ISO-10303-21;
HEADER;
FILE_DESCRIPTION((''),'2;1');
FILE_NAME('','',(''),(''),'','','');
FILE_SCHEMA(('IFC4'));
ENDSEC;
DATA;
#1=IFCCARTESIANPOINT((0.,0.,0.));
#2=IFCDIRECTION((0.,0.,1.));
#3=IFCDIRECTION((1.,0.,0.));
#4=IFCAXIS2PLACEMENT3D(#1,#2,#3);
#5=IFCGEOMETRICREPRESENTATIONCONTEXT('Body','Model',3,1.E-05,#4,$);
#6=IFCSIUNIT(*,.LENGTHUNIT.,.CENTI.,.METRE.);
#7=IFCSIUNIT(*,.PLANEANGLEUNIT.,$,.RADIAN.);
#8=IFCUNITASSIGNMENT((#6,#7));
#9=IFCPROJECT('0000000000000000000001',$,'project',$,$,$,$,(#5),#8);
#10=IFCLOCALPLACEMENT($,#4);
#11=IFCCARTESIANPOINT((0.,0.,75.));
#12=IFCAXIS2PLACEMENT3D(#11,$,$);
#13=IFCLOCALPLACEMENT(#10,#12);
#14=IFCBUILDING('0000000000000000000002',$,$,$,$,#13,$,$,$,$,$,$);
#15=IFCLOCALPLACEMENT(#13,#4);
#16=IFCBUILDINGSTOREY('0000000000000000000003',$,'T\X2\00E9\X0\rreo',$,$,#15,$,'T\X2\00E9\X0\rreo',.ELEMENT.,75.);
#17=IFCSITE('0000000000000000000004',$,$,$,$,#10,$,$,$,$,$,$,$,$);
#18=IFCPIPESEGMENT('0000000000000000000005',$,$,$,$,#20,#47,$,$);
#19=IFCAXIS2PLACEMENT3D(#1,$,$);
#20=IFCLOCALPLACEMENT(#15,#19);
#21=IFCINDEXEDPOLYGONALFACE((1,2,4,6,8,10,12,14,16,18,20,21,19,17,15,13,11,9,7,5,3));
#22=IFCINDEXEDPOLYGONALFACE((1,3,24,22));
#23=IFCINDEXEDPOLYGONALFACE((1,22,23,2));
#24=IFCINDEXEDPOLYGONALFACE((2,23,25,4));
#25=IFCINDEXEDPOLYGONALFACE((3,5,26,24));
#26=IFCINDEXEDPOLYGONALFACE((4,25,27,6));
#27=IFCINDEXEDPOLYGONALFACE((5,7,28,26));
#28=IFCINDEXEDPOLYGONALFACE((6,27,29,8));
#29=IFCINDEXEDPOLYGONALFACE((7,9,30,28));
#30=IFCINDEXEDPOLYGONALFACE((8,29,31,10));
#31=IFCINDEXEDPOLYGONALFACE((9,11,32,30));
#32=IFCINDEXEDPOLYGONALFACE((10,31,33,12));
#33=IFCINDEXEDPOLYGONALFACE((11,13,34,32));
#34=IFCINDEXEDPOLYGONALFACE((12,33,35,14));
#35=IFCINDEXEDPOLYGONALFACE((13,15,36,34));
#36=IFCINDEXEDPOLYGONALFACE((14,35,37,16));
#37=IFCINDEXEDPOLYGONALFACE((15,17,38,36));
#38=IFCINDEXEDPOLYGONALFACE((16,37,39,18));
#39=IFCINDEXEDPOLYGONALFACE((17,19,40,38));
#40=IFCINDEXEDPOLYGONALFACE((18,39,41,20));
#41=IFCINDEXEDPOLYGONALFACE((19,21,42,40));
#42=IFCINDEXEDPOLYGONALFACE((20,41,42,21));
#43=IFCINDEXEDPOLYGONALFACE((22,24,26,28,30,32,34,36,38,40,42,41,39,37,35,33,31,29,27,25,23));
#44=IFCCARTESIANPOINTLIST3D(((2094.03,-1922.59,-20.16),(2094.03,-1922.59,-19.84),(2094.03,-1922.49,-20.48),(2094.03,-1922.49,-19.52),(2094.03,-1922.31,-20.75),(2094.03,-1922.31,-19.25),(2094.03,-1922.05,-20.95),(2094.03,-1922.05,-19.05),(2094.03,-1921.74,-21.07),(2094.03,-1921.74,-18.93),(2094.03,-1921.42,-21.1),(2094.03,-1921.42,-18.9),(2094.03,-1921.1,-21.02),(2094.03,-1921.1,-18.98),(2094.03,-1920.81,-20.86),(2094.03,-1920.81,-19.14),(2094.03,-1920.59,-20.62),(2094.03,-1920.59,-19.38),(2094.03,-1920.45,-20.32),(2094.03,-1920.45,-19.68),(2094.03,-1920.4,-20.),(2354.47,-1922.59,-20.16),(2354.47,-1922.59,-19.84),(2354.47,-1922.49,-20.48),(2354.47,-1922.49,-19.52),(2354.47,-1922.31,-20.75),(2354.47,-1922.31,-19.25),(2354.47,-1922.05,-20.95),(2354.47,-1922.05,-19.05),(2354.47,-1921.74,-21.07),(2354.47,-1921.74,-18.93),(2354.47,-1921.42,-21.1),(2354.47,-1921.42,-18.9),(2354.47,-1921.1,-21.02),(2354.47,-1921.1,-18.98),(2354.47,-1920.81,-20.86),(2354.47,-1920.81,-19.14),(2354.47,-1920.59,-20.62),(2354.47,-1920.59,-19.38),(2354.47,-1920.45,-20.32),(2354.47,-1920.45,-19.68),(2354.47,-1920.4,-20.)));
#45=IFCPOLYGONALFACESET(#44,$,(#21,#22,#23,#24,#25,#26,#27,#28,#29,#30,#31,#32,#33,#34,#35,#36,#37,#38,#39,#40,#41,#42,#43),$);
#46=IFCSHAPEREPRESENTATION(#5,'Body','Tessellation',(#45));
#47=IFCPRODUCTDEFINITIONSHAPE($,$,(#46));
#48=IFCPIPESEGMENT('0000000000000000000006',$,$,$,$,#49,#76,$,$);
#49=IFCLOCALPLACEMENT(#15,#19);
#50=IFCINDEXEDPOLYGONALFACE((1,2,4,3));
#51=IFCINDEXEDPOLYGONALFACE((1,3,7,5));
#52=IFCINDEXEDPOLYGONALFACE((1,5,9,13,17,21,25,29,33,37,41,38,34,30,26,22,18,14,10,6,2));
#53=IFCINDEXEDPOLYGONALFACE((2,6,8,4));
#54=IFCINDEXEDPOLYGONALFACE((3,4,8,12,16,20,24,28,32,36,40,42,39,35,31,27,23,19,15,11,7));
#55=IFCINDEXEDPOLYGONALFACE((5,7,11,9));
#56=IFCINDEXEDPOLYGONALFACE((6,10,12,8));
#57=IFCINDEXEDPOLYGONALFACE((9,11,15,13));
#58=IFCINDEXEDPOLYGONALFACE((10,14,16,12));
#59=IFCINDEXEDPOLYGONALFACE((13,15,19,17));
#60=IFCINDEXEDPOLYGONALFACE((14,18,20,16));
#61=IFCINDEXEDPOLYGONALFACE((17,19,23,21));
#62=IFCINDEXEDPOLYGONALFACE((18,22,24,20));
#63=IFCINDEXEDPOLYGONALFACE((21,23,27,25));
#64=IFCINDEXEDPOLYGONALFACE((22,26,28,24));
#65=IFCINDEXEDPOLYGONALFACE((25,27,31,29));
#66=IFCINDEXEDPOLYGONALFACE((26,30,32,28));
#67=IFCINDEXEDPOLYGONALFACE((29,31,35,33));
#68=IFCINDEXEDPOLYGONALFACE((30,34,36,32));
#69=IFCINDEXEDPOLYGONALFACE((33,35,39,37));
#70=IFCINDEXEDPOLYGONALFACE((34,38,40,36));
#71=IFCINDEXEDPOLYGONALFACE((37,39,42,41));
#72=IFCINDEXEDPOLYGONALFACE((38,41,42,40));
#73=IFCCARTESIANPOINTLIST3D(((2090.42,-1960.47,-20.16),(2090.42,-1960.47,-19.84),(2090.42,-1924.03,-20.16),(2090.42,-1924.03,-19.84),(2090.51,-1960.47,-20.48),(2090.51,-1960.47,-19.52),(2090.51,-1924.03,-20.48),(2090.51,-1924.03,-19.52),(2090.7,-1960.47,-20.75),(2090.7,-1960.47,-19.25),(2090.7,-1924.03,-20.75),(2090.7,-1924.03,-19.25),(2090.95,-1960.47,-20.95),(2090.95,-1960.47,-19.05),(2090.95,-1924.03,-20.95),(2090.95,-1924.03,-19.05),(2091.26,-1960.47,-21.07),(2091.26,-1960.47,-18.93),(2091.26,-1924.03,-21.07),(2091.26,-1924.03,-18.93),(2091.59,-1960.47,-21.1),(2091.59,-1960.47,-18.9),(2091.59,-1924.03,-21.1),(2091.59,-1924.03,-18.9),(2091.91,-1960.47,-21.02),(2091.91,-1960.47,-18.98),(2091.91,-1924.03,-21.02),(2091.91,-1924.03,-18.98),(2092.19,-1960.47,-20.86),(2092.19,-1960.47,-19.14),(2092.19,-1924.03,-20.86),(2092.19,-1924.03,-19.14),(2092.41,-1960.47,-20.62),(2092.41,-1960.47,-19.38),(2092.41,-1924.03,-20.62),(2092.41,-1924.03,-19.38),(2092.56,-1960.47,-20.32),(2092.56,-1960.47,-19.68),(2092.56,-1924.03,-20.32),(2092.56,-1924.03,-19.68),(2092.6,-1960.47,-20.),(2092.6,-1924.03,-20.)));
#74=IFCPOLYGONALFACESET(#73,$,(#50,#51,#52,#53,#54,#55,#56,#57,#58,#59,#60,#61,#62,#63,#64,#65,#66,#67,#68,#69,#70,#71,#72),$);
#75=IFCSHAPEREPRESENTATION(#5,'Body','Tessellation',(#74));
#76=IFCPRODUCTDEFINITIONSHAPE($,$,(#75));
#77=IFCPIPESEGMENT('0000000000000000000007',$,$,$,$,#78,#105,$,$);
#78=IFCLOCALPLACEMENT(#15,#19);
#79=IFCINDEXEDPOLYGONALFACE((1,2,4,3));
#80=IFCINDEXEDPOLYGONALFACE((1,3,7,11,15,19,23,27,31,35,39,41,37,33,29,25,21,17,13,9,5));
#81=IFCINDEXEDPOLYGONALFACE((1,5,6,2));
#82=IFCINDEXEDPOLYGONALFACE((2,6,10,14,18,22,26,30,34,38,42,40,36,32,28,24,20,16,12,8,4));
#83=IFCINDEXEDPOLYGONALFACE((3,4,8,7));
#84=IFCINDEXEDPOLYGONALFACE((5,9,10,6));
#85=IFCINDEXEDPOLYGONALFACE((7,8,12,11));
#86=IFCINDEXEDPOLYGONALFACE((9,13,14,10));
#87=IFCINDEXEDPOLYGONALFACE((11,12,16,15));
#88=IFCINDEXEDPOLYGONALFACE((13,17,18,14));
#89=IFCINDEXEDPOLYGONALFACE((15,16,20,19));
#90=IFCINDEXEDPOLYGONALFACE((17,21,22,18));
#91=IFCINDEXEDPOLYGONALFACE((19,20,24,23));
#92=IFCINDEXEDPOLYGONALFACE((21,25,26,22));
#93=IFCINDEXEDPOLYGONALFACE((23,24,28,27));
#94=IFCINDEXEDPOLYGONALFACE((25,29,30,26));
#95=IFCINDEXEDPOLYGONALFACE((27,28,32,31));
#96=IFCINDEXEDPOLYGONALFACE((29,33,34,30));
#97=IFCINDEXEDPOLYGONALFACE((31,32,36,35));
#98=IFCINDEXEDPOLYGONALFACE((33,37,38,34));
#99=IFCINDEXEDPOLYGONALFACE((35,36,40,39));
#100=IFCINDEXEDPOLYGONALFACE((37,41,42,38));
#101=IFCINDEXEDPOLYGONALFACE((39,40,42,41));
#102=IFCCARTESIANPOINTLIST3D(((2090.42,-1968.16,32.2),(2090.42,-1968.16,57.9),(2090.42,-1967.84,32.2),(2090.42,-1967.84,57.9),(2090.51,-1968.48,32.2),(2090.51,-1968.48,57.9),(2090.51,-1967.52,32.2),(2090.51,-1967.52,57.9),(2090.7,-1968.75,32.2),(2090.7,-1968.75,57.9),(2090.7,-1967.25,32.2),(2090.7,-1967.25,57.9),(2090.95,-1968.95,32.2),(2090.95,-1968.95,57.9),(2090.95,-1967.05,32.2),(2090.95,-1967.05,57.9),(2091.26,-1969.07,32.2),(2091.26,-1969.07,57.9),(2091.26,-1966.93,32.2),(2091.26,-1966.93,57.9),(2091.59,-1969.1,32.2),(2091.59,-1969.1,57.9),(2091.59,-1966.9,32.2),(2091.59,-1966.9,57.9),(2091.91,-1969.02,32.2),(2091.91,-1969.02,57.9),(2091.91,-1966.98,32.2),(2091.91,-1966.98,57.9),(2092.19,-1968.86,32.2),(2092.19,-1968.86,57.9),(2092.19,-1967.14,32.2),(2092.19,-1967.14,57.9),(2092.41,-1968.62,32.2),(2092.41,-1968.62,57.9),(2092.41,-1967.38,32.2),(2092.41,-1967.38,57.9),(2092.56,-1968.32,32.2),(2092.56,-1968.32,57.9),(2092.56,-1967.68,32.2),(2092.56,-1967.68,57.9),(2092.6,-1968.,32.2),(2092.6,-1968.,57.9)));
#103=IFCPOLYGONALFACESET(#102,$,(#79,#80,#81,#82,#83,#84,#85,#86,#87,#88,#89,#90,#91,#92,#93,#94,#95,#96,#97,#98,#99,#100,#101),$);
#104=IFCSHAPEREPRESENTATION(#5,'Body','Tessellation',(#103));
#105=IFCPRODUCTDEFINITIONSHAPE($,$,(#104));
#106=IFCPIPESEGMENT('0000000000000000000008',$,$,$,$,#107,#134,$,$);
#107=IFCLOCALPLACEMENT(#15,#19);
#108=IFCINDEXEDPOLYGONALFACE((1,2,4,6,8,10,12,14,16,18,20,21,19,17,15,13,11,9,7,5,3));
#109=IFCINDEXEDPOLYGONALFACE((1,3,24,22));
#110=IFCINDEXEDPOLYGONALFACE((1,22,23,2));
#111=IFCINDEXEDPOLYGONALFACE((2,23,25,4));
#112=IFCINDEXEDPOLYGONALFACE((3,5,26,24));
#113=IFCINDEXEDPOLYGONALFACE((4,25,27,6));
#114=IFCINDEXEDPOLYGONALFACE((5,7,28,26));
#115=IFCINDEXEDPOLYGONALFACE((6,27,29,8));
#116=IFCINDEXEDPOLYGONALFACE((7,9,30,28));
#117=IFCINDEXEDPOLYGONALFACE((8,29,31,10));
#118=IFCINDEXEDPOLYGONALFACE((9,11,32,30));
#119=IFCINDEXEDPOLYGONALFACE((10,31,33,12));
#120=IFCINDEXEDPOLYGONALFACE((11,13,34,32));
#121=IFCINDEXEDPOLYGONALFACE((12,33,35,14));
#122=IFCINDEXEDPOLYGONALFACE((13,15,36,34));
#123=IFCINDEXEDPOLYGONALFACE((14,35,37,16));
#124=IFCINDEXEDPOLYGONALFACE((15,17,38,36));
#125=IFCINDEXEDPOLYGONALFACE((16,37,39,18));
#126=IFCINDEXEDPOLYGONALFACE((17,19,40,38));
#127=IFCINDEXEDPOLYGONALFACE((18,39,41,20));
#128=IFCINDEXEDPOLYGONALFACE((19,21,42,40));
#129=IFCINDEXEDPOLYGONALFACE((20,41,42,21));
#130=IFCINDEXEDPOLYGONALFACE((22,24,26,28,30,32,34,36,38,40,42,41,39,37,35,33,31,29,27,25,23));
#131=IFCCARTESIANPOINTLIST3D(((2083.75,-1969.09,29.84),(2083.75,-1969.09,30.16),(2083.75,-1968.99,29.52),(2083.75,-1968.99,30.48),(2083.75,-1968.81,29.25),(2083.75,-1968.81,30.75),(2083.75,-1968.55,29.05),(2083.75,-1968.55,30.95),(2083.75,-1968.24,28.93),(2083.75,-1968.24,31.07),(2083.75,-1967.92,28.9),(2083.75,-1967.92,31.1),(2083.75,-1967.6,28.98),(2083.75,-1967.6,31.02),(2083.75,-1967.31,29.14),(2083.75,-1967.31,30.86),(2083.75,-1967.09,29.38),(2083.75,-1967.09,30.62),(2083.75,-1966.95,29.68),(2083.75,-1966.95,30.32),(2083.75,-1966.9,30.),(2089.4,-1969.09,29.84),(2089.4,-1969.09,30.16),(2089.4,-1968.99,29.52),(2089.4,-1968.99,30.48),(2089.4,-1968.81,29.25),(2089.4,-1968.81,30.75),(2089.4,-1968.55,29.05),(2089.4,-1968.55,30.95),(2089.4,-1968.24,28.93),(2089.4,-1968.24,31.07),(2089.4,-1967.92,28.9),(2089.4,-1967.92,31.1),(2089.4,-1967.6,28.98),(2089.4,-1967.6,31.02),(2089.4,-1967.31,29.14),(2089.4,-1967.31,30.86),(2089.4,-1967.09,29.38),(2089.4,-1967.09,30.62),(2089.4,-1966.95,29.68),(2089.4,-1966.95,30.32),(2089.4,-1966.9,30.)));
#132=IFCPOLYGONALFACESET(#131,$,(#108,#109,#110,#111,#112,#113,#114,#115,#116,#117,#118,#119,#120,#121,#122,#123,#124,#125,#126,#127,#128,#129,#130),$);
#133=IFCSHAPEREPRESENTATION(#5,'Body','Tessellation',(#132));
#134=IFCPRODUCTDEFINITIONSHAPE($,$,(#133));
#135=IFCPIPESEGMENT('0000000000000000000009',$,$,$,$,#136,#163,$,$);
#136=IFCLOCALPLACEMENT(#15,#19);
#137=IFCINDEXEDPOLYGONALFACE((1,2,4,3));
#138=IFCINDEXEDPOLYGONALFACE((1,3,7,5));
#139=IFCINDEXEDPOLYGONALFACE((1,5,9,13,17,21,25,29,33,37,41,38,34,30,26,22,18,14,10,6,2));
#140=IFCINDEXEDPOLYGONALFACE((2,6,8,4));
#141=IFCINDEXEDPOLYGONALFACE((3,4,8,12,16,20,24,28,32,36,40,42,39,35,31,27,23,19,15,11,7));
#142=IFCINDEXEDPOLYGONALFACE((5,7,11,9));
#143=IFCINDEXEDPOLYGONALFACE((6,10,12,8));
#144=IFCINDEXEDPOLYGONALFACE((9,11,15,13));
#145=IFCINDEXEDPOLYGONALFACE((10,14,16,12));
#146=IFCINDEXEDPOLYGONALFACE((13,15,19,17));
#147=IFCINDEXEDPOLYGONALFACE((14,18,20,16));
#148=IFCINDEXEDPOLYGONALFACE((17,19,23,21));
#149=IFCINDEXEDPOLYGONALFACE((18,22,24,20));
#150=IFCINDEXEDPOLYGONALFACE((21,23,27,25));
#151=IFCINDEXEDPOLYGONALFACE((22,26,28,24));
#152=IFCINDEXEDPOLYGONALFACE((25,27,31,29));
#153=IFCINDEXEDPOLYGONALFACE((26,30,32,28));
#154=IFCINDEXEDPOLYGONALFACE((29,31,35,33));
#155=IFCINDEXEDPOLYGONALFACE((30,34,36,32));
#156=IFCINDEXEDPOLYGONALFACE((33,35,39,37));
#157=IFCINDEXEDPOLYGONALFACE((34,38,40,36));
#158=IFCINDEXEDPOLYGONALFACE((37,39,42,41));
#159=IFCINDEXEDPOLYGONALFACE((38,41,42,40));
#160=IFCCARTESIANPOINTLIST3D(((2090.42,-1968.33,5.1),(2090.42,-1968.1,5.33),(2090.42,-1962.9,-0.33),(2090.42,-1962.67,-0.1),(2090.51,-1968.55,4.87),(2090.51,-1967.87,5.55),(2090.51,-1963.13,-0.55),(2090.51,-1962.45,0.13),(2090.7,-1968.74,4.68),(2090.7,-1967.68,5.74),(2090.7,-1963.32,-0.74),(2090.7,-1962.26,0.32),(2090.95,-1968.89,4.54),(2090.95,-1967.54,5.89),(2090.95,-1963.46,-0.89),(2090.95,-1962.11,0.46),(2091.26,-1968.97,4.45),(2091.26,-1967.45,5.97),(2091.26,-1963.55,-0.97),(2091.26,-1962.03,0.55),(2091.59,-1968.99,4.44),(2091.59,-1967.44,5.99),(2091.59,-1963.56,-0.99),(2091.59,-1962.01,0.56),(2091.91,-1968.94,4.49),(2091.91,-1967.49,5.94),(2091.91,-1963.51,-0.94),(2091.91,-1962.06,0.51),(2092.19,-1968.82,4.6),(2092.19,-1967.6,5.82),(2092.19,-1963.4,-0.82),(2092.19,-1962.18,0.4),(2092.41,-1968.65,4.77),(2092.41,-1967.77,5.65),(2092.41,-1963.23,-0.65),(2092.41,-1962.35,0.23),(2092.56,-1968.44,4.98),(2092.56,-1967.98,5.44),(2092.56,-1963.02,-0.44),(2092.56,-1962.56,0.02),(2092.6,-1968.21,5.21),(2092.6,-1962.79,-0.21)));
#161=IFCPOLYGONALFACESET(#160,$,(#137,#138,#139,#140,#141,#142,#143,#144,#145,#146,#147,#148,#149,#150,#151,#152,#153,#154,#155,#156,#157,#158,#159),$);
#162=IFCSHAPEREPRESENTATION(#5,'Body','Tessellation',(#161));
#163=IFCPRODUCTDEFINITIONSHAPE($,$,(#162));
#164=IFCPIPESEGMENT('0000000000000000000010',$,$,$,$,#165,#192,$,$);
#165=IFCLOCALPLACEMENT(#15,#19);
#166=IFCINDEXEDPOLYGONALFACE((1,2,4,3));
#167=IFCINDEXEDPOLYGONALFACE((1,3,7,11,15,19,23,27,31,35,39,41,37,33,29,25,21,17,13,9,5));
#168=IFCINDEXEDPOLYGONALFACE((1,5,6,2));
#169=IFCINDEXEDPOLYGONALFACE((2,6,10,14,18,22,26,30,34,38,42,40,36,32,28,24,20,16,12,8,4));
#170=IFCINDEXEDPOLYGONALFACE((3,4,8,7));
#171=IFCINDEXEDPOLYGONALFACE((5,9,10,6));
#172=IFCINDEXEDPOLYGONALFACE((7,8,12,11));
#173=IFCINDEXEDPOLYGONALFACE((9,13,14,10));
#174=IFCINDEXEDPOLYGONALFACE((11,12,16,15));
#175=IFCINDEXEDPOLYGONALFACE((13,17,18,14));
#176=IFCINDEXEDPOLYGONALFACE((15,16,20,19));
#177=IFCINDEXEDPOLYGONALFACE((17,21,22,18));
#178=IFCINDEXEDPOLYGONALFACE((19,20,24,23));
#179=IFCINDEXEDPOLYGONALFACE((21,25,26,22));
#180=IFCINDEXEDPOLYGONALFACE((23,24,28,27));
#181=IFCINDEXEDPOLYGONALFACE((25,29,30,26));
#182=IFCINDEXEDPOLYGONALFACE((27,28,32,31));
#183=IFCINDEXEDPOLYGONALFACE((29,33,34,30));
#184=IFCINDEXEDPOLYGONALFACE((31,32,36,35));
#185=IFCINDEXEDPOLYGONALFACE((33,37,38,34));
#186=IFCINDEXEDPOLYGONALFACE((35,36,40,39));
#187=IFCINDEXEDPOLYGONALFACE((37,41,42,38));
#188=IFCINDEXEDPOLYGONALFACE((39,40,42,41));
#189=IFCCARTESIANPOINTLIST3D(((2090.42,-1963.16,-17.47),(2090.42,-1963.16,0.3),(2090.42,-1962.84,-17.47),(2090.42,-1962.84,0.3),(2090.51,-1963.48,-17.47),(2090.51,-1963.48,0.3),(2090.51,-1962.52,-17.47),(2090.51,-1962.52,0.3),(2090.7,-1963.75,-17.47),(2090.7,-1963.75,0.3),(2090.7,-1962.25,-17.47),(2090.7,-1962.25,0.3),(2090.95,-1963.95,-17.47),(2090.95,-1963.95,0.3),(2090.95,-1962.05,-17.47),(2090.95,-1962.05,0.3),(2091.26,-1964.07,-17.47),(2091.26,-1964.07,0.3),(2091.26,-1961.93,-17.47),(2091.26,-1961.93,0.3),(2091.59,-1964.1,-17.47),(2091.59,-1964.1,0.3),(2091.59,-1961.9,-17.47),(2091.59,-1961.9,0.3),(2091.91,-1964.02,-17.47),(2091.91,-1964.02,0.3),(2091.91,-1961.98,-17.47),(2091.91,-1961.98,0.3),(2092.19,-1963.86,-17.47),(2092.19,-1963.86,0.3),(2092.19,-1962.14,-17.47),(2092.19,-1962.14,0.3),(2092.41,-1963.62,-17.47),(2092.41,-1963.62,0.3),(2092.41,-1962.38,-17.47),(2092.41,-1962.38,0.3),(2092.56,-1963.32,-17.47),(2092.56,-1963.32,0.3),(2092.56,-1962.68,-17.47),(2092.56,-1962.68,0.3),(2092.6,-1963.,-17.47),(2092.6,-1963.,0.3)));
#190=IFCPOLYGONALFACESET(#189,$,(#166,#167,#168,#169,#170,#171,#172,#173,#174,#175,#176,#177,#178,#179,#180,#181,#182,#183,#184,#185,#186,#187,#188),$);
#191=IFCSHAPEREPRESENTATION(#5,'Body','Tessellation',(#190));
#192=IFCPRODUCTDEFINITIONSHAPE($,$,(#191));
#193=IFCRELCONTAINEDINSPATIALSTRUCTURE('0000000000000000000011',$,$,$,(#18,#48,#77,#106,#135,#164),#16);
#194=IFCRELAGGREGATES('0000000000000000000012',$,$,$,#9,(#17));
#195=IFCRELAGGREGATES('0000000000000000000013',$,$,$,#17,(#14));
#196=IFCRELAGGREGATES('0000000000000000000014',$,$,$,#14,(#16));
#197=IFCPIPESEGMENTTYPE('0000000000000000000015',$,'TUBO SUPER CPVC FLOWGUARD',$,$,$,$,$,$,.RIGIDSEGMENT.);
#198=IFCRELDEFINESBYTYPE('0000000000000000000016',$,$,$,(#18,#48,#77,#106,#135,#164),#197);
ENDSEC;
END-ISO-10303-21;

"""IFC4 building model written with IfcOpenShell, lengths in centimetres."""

from ifc_helpers import new_model, si_unit, frame, origin_with_axes, origin_2d_with_axis, place, context, project, spatial, circle, extrude, type_object, element, save


model = new_model("IFC4")

# Units and contexts
model_context = context("Model", 3, precision=1e-05, world=origin_with_axes(), identifier="Body")
ifc_project = project(units=[si_unit("LENGTHUNIT", "METRE", prefix="CENTI"), si_unit("PLANEANGLEUNIT", "RADIAN")], contexts=[model_context])

# Site, building, storey
site_placement = place(None, origin_with_axes())
site = spatial("IfcSite", under=ifc_project, at=site_placement)
building_placement = place(site_placement, frame((0.0, 0.0, 75.0)))
building = spatial("IfcBuilding", under=site, at=building_placement)
storey_placement = place(building_placement, origin_with_axes())
storey = spatial("IfcBuildingStorey", under=building, at=storey_placement, Name="Térreo", LongName="Térreo", CompositionType="ELEMENT", Elevation=75.0)

# Pipe segments
pipe_segment_type_1 = type_object("IfcPipeSegmentType", Name="TUBO SUPER CPVC FLOWGUARD", PredefinedType="RIGIDSEGMENT")
pipe_segment_1_placement = place(storey_placement, frame((2224.25, -1921.5, -18.9), z_axis=(0.0, 0.0, 1.0), x_axis=(1.0, 0.0, 0.0)))
element("IfcPipeSegment", 1, at=pipe_segment_1_placement, inside=storey, type_object=pipe_segment_type_1, context=model_context, shape_type="SolidModel", body=[
    extrude(circle(Radius=1.1, at=origin_2d_with_axis()), frame((130.22, 0.0, -1.1), z_axis=(-1.0, 0.0, 0.0), x_axis=(0.0, 1.0, 0.0)), (0.0, 0.0, 1.0), 260.44),
])
pipe_segment_2_placement = place(storey_placement, frame((2091.5, -1942.25, -18.9), z_axis=(0.0, 0.0, 1.0), x_axis=(1.0, 0.0, 0.0)))
element("IfcPipeSegment", 2, at=pipe_segment_2_placement, inside=storey, type_object=pipe_segment_type_1, context=model_context, shape_type="SolidModel", body=[
    extrude(circle(Radius=1.1, at=origin_2d_with_axis()), frame((0.0, 18.22, -1.1), z_axis=(0.0, -1.0, 0.0), x_axis=(1.0, 0.0, 0.0)), (0.0, 0.0, 1.0), 36.44),
])
pipe_segment_3_placement = place(storey_placement, frame((2091.5, -1968.0, 57.9), z_axis=(0.0, 0.0, 1.0), x_axis=(1.0, 0.0, 0.0)))
element("IfcPipeSegment", 3, at=pipe_segment_3_placement, inside=storey, type_object=pipe_segment_type_1, context=model_context, shape_type="SolidModel", body=[
    extrude(circle(Radius=1.1, at=origin_2d_with_axis()), frame((0.0, 0.0, -25.7), z_axis=(0.0, 0.0, 1.0), x_axis=(1.0, 0.0, 0.0)), (0.0, 0.0, 1.0), 25.7),
])
pipe_segment_4_placement = place(storey_placement, frame((2086.58, -1968.0, 31.1), z_axis=(0.0, 0.0, 1.0), x_axis=(1.0, 0.0, 0.0)))
element("IfcPipeSegment", 4, at=pipe_segment_4_placement, inside=storey, type_object=pipe_segment_type_1, context=model_context, shape_type="SolidModel", body=[
    extrude(circle(Radius=1.1, at=origin_2d_with_axis()), frame((2.82, 0.0, -1.1), z_axis=(-1.0, 0.0, 0.0), x_axis=(0.0, 1.0, 0.0)), (0.0, 0.0, 1.0), 5.65),
])
pipe_segment_5_placement = place(storey_placement, frame((2091.5, -1965.5, 5.99), z_axis=(0.0, 0.0, 1.0), x_axis=(1.0, 0.0, 0.0)))
element("IfcPipeSegment", 5, at=pipe_segment_5_placement, inside=storey, type_object=pipe_segment_type_1, context=model_context, shape_type="SolidModel", body=[
    extrude(circle(Radius=1.1, at=origin_2d_with_axis()), frame((0.0, 2.71, -6.2), z_axis=(0.0, -0.707107, 0.707107), x_axis=(1.0, 0.0, 0.0)), (0.0, 0.0, 1.0), 7.67),
])
pipe_segment_6_placement = place(storey_placement, frame((2091.5, -1963.0, 0.3), z_axis=(0.0, 0.0, 1.0), x_axis=(1.0, 0.0, 0.0)))
element("IfcPipeSegment", 6, at=pipe_segment_6_placement, inside=storey, type_object=pipe_segment_type_1, context=model_context, shape_type="SolidModel", body=[
    extrude(circle(Radius=1.1, at=origin_2d_with_axis()), frame((0.0, 0.0, -17.77), z_axis=(0.0, 0.0, 1.0), x_axis=(1.0, 0.0, 0.0)), (0.0, 0.0, 1.0), 17.77),
])

save(model, "model.ifc")
